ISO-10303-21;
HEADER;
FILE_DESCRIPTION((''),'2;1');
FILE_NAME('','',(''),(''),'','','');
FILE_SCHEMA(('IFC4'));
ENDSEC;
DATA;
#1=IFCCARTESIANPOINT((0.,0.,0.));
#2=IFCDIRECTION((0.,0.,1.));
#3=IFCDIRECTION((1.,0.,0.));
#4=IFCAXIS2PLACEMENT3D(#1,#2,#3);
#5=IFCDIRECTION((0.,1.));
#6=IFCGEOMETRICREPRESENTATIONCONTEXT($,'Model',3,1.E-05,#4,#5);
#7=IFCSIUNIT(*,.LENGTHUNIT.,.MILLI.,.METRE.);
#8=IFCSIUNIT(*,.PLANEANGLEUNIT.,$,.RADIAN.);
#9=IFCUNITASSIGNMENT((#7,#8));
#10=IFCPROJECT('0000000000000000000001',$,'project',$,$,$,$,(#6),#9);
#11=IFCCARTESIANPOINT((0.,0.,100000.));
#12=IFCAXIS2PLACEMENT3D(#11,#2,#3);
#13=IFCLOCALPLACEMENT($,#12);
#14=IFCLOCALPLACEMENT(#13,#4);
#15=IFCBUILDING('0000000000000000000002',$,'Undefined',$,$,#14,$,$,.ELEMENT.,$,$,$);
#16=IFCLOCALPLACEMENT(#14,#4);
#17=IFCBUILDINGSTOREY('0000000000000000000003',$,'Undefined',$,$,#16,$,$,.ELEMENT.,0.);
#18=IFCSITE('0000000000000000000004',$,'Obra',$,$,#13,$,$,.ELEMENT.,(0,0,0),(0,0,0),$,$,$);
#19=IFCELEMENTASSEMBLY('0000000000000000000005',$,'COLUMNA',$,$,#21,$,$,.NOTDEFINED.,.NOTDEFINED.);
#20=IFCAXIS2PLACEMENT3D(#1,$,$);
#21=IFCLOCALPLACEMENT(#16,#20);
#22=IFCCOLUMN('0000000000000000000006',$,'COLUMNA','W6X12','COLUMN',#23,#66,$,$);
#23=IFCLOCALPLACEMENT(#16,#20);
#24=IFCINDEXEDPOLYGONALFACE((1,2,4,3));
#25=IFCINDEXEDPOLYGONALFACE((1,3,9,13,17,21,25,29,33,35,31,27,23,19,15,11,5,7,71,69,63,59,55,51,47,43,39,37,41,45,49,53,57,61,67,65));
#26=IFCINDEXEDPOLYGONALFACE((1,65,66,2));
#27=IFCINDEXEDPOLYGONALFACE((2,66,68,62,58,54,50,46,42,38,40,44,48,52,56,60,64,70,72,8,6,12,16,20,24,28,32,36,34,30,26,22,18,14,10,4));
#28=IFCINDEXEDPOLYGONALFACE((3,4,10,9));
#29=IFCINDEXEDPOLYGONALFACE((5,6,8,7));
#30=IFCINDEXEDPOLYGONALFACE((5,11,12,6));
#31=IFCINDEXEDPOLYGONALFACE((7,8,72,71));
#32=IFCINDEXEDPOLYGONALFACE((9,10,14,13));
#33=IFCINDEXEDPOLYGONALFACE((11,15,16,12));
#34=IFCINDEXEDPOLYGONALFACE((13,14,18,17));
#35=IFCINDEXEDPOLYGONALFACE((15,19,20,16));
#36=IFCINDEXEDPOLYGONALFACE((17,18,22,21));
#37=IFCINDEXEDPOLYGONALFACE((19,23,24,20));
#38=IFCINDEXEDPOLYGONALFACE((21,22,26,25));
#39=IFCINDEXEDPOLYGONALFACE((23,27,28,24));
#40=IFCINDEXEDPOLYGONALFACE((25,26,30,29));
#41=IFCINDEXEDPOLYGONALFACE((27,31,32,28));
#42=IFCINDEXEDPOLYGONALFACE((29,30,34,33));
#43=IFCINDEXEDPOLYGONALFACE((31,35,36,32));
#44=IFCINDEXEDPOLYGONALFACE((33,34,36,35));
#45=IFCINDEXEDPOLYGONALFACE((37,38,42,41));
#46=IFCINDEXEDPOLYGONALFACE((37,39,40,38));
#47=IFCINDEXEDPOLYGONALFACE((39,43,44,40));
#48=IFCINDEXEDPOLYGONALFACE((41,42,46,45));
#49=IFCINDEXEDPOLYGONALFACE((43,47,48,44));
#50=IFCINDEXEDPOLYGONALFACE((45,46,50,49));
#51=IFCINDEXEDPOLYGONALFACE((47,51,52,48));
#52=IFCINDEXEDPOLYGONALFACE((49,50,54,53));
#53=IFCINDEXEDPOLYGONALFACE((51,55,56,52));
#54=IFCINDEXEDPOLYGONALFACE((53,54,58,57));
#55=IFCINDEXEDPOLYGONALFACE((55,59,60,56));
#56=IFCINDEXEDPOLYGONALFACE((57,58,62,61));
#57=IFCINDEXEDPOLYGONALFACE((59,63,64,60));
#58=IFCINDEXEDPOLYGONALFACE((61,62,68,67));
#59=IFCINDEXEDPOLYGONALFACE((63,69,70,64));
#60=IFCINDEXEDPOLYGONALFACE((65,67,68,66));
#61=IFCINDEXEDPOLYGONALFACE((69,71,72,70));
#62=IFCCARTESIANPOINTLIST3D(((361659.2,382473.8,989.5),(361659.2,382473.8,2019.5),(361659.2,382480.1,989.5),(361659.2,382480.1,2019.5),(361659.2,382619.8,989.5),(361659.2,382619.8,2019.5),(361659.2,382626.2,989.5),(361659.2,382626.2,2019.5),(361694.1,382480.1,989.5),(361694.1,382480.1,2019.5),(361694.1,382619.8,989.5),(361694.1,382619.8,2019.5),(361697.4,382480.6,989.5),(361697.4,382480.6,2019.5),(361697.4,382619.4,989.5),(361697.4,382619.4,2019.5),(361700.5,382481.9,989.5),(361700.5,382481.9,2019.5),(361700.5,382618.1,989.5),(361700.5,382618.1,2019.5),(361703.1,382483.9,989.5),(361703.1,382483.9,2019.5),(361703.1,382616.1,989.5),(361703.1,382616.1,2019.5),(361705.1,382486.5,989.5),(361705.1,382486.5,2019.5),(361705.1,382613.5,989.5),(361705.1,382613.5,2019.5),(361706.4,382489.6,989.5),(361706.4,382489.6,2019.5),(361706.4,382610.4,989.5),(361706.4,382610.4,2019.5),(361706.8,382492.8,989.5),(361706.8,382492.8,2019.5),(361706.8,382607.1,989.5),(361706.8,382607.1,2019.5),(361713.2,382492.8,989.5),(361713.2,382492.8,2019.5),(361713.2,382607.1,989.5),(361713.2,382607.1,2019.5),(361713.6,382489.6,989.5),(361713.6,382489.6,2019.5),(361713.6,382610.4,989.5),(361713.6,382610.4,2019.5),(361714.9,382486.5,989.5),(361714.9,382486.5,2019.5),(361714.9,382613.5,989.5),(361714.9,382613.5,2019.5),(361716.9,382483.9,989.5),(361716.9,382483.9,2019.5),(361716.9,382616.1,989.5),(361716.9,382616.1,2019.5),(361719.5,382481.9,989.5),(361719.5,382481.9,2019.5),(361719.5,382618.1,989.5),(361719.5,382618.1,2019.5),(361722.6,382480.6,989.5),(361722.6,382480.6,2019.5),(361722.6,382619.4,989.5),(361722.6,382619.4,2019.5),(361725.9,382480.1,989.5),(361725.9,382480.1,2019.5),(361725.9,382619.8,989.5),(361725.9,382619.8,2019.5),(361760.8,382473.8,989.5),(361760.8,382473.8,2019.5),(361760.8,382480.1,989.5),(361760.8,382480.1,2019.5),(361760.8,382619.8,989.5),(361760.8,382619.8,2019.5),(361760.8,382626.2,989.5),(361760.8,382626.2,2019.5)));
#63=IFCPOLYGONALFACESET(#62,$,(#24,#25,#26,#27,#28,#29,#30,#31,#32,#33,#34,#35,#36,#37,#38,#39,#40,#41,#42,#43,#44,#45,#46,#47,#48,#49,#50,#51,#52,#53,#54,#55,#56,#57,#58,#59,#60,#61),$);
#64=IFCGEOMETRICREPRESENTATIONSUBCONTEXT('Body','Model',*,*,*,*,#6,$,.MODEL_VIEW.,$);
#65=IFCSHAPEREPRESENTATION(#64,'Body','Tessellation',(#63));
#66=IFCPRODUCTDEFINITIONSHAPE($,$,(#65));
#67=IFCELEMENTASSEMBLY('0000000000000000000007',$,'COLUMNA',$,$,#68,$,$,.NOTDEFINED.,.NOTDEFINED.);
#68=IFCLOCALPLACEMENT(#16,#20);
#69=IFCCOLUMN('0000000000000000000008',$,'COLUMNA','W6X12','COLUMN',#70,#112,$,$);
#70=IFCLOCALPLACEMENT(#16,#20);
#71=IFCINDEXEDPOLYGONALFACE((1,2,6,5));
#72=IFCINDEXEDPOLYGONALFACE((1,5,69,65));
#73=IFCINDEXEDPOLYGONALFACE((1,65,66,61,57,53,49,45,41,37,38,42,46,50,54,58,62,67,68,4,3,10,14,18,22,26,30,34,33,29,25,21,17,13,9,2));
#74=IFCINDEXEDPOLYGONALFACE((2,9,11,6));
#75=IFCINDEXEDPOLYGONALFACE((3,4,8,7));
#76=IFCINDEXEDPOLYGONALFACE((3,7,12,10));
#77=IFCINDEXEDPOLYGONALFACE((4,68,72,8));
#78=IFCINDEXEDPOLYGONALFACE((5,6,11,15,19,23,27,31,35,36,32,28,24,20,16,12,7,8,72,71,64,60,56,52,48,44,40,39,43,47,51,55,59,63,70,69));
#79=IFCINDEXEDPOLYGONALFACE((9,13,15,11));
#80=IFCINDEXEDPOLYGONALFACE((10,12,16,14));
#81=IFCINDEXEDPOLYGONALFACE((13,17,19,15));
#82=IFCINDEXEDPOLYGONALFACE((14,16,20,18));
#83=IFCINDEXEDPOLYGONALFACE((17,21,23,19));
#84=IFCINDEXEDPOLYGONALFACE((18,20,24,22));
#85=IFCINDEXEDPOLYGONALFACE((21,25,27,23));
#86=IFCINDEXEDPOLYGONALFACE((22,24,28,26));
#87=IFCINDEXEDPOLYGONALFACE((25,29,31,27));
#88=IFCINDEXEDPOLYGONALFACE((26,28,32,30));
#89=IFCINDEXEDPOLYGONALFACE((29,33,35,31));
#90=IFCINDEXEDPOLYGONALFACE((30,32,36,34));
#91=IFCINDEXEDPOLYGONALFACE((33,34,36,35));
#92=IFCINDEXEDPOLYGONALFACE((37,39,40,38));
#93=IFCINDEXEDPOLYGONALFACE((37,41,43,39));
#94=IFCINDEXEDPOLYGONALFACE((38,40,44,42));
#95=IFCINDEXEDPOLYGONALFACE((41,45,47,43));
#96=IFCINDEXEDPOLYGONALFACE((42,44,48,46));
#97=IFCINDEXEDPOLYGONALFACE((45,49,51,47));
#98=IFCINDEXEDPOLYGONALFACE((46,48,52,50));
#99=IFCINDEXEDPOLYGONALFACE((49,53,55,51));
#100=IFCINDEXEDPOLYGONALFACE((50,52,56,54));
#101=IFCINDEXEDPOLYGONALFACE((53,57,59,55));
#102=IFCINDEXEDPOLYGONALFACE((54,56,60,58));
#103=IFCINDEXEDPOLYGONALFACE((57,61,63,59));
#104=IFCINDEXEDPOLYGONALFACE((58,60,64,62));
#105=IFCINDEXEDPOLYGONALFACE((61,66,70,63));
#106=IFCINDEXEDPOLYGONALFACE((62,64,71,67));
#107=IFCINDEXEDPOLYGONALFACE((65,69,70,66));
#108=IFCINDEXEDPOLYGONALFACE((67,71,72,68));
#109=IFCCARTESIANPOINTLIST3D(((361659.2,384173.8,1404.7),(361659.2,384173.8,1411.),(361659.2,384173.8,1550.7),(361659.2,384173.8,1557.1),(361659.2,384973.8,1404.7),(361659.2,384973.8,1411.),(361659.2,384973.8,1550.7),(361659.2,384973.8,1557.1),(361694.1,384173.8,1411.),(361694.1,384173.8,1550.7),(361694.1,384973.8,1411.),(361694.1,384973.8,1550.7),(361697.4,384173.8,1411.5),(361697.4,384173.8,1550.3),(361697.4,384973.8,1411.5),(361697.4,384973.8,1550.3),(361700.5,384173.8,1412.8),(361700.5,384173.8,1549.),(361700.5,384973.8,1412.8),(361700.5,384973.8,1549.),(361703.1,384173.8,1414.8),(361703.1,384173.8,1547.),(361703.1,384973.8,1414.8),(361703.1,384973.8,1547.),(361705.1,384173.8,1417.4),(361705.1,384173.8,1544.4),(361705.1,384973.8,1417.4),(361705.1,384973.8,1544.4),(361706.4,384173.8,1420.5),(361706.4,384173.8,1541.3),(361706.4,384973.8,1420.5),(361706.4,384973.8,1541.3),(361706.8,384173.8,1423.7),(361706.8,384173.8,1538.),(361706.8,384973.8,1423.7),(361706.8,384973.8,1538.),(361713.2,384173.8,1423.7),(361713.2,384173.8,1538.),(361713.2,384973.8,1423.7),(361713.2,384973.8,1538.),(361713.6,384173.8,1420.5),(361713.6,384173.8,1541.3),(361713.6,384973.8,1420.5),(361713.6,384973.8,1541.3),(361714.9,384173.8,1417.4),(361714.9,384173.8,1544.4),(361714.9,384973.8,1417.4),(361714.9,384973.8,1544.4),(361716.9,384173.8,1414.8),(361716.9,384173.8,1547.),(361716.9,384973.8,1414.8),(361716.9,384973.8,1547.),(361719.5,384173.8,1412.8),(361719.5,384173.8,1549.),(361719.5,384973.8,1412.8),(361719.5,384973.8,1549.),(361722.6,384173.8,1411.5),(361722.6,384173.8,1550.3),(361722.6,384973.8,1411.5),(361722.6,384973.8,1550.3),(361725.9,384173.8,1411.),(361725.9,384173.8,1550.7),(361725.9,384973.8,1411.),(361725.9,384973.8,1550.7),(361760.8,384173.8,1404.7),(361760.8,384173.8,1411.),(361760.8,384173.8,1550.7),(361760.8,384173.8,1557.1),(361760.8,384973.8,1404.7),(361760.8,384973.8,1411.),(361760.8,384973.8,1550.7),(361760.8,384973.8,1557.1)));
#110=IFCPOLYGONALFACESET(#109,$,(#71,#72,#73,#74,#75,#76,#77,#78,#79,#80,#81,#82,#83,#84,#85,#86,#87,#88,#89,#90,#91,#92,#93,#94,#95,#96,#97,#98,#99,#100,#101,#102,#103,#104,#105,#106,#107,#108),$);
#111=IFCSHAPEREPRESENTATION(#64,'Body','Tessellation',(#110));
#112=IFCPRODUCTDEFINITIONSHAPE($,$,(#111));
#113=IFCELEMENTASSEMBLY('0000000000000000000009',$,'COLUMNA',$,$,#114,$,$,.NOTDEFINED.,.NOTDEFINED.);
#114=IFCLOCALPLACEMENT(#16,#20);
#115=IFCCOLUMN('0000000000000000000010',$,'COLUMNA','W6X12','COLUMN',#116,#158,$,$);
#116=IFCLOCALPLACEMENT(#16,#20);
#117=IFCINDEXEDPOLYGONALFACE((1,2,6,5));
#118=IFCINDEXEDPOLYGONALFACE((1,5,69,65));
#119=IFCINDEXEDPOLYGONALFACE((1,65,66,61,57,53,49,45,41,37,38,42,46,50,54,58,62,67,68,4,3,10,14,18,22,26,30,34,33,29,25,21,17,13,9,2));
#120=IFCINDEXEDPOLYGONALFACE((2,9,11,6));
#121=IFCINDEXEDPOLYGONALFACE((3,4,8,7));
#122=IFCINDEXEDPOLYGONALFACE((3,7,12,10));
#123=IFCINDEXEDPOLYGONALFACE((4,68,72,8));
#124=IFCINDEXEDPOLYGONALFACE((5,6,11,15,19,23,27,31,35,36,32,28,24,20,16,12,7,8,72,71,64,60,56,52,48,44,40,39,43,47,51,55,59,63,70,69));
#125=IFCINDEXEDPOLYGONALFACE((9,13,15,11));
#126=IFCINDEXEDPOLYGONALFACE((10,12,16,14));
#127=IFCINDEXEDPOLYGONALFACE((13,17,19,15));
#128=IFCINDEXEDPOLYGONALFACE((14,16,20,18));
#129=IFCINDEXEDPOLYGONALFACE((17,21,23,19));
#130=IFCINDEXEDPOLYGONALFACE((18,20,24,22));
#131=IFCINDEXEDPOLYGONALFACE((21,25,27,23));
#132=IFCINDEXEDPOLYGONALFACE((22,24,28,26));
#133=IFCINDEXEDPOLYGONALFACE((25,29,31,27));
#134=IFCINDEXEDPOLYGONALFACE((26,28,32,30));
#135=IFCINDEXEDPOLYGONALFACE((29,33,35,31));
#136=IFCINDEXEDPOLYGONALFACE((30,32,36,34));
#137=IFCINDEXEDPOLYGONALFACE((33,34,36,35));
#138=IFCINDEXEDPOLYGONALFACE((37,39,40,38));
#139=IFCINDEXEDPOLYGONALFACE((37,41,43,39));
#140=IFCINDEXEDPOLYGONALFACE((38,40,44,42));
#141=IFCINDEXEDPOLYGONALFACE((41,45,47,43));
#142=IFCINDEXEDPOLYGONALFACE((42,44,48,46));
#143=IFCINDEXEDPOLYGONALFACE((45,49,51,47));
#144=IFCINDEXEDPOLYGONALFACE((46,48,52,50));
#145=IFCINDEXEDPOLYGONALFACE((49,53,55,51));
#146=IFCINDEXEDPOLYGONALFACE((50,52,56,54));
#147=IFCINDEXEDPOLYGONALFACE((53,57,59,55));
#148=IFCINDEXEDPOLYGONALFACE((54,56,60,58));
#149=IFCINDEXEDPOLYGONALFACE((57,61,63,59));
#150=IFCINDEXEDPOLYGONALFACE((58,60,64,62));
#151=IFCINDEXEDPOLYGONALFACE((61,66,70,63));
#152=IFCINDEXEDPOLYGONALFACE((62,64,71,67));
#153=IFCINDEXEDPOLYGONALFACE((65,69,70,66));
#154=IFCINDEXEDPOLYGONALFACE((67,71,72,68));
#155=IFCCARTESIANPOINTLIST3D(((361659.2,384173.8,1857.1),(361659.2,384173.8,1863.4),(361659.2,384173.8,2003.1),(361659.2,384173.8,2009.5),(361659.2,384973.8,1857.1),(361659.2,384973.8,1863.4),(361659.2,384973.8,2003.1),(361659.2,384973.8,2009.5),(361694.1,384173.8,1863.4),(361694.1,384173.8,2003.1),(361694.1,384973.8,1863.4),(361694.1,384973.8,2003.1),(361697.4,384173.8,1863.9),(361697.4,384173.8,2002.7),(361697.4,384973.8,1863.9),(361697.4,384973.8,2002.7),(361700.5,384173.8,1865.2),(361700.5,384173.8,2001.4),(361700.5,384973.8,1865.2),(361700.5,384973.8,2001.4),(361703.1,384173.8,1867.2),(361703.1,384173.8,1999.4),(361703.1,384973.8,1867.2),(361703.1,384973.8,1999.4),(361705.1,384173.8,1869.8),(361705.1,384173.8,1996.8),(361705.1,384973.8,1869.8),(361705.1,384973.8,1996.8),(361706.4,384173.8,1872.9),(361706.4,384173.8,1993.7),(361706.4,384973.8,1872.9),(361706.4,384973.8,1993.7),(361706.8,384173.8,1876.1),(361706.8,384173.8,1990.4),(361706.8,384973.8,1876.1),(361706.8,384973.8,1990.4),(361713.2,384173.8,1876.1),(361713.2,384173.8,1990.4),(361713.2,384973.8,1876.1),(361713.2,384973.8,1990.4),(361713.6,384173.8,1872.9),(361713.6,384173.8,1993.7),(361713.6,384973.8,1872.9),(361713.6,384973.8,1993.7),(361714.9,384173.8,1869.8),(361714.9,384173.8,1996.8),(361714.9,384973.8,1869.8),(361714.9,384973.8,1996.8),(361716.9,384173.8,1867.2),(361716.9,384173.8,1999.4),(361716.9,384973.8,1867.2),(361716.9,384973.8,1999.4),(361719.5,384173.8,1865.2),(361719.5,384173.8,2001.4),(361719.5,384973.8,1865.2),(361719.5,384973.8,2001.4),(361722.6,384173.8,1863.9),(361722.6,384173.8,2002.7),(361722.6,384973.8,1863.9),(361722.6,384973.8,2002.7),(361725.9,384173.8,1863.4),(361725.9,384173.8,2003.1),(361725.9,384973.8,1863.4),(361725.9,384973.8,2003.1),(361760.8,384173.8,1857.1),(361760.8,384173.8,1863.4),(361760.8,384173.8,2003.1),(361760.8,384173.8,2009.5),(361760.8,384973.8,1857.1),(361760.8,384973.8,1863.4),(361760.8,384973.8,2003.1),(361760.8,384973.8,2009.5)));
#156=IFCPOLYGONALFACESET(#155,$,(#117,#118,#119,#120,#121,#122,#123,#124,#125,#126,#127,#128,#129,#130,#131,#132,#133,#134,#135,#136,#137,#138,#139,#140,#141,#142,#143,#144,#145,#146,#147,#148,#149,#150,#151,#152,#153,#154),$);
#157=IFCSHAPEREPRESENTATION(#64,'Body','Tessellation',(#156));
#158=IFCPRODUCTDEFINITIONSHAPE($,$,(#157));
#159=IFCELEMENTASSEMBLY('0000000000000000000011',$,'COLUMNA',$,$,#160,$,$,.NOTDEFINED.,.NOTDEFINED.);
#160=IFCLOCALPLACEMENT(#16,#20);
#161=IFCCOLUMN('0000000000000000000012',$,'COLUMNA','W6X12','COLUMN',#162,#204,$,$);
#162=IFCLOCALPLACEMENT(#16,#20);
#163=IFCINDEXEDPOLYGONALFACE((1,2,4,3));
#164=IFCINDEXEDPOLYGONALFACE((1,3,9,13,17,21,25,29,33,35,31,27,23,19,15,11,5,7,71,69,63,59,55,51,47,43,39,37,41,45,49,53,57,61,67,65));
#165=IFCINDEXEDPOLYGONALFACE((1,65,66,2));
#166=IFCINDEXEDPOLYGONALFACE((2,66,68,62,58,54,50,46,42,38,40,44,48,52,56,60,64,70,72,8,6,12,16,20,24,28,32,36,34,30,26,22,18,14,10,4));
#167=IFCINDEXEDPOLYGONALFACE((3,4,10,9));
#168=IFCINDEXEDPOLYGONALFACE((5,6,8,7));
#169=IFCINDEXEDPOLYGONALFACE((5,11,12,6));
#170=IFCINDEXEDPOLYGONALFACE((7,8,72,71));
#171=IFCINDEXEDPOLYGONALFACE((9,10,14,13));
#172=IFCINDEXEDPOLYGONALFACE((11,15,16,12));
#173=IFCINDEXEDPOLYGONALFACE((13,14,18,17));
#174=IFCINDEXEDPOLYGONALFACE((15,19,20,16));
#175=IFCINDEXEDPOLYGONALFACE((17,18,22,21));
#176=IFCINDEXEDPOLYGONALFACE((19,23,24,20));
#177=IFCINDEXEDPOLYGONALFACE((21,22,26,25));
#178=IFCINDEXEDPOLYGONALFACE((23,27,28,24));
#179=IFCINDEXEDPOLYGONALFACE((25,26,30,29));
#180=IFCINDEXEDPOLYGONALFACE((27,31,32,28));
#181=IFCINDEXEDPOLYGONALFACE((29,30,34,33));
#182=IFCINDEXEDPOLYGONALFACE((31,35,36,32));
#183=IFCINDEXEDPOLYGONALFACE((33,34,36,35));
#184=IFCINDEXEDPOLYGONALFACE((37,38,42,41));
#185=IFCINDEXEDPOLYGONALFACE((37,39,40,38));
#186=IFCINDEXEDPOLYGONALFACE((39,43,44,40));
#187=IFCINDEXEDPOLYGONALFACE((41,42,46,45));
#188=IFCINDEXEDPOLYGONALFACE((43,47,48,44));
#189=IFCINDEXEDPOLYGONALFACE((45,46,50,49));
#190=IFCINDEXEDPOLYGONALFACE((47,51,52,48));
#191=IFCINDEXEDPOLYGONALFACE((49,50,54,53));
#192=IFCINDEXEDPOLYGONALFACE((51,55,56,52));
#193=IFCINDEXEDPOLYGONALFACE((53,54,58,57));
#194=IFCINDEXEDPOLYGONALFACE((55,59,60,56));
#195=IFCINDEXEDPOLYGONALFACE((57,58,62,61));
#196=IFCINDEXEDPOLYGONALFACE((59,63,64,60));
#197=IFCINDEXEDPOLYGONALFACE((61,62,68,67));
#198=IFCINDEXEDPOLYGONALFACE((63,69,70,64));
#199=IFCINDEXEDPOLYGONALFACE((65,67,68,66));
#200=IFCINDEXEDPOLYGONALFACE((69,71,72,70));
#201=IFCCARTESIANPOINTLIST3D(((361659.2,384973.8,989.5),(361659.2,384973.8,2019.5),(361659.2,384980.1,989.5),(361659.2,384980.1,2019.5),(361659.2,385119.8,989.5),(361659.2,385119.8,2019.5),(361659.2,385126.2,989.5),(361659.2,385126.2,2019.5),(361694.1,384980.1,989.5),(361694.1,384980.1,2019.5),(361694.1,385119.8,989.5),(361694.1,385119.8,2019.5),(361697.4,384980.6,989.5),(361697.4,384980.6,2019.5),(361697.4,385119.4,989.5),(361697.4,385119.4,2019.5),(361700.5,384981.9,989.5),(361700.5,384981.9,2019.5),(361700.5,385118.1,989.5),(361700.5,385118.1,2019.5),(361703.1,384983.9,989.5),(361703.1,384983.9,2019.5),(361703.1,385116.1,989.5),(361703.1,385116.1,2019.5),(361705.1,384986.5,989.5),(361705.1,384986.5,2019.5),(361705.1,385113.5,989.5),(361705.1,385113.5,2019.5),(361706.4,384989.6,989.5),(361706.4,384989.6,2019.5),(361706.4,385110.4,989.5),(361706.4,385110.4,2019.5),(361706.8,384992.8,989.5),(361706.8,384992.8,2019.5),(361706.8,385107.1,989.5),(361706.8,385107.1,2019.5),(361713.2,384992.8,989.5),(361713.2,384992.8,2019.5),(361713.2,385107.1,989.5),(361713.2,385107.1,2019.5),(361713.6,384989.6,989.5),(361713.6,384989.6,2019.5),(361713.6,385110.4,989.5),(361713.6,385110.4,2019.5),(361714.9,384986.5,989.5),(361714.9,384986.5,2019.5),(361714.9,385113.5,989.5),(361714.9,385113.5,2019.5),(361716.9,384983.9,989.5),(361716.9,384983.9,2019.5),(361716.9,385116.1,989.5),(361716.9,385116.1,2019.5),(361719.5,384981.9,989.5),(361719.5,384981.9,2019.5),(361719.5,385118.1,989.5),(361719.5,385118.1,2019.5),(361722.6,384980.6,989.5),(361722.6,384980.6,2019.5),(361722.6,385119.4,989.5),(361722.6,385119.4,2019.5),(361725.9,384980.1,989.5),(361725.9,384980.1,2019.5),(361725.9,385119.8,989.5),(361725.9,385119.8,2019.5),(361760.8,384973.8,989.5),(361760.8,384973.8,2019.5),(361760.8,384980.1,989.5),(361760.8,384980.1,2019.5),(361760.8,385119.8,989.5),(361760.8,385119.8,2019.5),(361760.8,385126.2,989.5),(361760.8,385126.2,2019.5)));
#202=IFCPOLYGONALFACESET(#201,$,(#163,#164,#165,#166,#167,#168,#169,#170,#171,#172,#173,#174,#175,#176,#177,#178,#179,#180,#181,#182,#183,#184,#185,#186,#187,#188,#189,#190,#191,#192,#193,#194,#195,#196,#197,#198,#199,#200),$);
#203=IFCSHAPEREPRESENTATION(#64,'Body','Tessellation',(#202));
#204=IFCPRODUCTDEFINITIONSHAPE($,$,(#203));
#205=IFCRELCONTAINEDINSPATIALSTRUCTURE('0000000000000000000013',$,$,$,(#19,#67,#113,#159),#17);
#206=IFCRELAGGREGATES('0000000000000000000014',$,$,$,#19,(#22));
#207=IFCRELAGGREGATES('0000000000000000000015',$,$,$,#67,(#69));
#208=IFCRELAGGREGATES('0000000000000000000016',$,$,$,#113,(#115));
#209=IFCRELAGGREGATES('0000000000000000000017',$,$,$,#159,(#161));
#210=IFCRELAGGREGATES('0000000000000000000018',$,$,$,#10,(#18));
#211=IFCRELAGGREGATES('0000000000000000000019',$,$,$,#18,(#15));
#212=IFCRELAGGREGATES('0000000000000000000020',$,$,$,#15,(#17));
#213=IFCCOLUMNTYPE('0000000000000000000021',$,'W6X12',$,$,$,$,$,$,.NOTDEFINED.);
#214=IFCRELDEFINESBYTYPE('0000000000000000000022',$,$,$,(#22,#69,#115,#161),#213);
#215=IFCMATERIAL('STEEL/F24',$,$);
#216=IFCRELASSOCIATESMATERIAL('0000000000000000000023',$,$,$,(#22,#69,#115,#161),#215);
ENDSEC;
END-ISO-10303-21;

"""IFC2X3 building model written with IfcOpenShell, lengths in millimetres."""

from ifc_helpers import new_model, si_unit, direction, frame, origin_with_axes, origin_2d_with_axis, place, context, subcontext, project, spatial, i_section, extrude, material, type_object, element, aggregate, save


model = new_model("IFC2X3")

# Units and contexts
model_context = context("Model", 3, precision=1e-05, world=origin_with_axes(), true_north=direction((0.0, 1.0)))
body_context = subcontext(model_context, "Body", "Model", "MODEL_VIEW")
ifc_project = project(units=[si_unit("LENGTHUNIT", "METRE", prefix="MILLI"), si_unit("PLANEANGLEUNIT", "RADIAN")], contexts=[model_context])

# Site, building, storey
site_placement = place(None, frame((0.0, 0.0, 100000.0), z_axis=(0.0, 0.0, 1.0), x_axis=(1.0, 0.0, 0.0)))
site = spatial("IfcSite", under=ifc_project, at=site_placement, Name="Obra", CompositionType="ELEMENT", RefLatitude=(0, 0, 0), RefLongitude=(0, 0, 0))
building_placement = place(site_placement, origin_with_axes())
building = spatial("IfcBuilding", under=site, at=building_placement, Name="Undefined", CompositionType="ELEMENT")
storey_placement = place(building_placement, origin_with_axes())
storey = spatial("IfcBuildingStorey", under=building, at=storey_placement, Name="Undefined", CompositionType="ELEMENT", Elevation=0.0)

# Element assemblies, columns
ifc_material_1 = material(Name="STEEL/F24")
column_type_1 = type_object("IfcColumnType", Name="W6X12", PredefinedType="NOTDEFINED")
assembly_1_placement = place(storey_placement, origin_with_axes())
assembly_1 = element("IfcElementAssembly", 1, at=assembly_1_placement, inside=storey, Name="COLUMNA", AssemblyPlace="NOTDEFINED", PredefinedType="NOTDEFINED")
column_1_placement = place(assembly_1_placement, frame((361710.0, 382550.0, 989.5), z_axis=(0.0, 0.0, 1.0), x_axis=(0.0, -1.0, 0.0)))
column_1 = element("IfcColumn", 2, at=column_1_placement, type_object=column_type_1, material=ifc_material_1, Name="COLUMNA", Description="W6X12", ObjectType="COLUMN", context=body_context, shape_type="SweptSolid", body=[
    extrude(i_section(OverallWidth=101.6, OverallDepth=152.4, WebThickness=6.3, FlangeThickness=6.3, FilletRadius=12.7, at=origin_2d_with_axis()), frame((0.0, 0.0, 1030.0), z_axis=(0.0, 0.0, -1.0), x_axis=(0.0, 1.0, 0.0)), (0.0, 0.0, 1.0), 1030.0),
])
aggregate(assembly_1, [column_1])
assembly_2_placement = place(storey_placement, origin_with_axes())
assembly_2 = element("IfcElementAssembly", 3, at=assembly_2_placement, inside=storey, Name="COLUMNA", AssemblyPlace="NOTDEFINED", PredefinedType="NOTDEFINED")
column_2_placement = place(assembly_2_placement, frame((361710.0, 384973.8, 1480.9), z_axis=(0.0, -1.0, 0.0), x_axis=(0.0, 0.0, -1.0)))
column_2 = element("IfcColumn", 4, at=column_2_placement, type_object=column_type_1, material=ifc_material_1, Name="COLUMNA", Description="W6X12", ObjectType="COLUMN", context=body_context, shape_type="SweptSolid", body=[
    extrude(i_section(OverallWidth=101.6, OverallDepth=152.4, WebThickness=6.3, FlangeThickness=6.3, FilletRadius=12.7, at=origin_2d_with_axis()), frame((0.0, 0.0, 800.0), z_axis=(0.0, 0.0, -1.0), x_axis=(0.0, 1.0, 0.0)), (0.0, 0.0, 1.0), 800.0),
])
aggregate(assembly_2, [column_2])
assembly_3_placement = place(storey_placement, origin_with_axes())
assembly_3 = element("IfcElementAssembly", 5, at=assembly_3_placement, inside=storey, Name="COLUMNA", AssemblyPlace="NOTDEFINED", PredefinedType="NOTDEFINED")
column_3_placement = place(assembly_3_placement, frame((361710.0, 384973.8, 1933.3), z_axis=(0.0, -1.0, 0.0), x_axis=(0.0, 0.0, -1.0)))
column_3 = element("IfcColumn", 6, at=column_3_placement, type_object=column_type_1, material=ifc_material_1, Name="COLUMNA", Description="W6X12", ObjectType="COLUMN", context=body_context, shape_type="SweptSolid", body=[
    extrude(i_section(OverallWidth=101.6, OverallDepth=152.4, WebThickness=6.3, FlangeThickness=6.3, FilletRadius=12.7, at=origin_2d_with_axis()), frame((0.0, 0.0, 800.0), z_axis=(0.0, 0.0, -1.0), x_axis=(0.0, 1.0, 0.0)), (0.0, 0.0, 1.0), 800.0),
])
aggregate(assembly_3, [column_3])
assembly_4_placement = place(storey_placement, origin_with_axes())
assembly_4 = element("IfcElementAssembly", 7, at=assembly_4_placement, inside=storey, Name="COLUMNA", AssemblyPlace="NOTDEFINED", PredefinedType="NOTDEFINED")
column_4_placement = place(assembly_4_placement, frame((361710.0, 385050.0, 989.5), z_axis=(0.0, 0.0, 1.0), x_axis=(0.0, 1.0, 0.0)))
column_4 = element("IfcColumn", 8, at=column_4_placement, type_object=column_type_1, material=ifc_material_1, Name="COLUMNA", Description="W6X12", ObjectType="COLUMN", context=body_context, shape_type="SweptSolid", body=[
    extrude(i_section(OverallWidth=101.6, OverallDepth=152.4, WebThickness=6.3, FlangeThickness=6.3, FilletRadius=12.7, at=origin_2d_with_axis()), frame((0.0, 0.0, 1030.0), z_axis=(0.0, 0.0, -1.0), x_axis=(0.0, 1.0, 0.0)), (0.0, 0.0, 1.0), 1030.0),
])
aggregate(assembly_4, [column_4])

save(model, "model.ifc")
